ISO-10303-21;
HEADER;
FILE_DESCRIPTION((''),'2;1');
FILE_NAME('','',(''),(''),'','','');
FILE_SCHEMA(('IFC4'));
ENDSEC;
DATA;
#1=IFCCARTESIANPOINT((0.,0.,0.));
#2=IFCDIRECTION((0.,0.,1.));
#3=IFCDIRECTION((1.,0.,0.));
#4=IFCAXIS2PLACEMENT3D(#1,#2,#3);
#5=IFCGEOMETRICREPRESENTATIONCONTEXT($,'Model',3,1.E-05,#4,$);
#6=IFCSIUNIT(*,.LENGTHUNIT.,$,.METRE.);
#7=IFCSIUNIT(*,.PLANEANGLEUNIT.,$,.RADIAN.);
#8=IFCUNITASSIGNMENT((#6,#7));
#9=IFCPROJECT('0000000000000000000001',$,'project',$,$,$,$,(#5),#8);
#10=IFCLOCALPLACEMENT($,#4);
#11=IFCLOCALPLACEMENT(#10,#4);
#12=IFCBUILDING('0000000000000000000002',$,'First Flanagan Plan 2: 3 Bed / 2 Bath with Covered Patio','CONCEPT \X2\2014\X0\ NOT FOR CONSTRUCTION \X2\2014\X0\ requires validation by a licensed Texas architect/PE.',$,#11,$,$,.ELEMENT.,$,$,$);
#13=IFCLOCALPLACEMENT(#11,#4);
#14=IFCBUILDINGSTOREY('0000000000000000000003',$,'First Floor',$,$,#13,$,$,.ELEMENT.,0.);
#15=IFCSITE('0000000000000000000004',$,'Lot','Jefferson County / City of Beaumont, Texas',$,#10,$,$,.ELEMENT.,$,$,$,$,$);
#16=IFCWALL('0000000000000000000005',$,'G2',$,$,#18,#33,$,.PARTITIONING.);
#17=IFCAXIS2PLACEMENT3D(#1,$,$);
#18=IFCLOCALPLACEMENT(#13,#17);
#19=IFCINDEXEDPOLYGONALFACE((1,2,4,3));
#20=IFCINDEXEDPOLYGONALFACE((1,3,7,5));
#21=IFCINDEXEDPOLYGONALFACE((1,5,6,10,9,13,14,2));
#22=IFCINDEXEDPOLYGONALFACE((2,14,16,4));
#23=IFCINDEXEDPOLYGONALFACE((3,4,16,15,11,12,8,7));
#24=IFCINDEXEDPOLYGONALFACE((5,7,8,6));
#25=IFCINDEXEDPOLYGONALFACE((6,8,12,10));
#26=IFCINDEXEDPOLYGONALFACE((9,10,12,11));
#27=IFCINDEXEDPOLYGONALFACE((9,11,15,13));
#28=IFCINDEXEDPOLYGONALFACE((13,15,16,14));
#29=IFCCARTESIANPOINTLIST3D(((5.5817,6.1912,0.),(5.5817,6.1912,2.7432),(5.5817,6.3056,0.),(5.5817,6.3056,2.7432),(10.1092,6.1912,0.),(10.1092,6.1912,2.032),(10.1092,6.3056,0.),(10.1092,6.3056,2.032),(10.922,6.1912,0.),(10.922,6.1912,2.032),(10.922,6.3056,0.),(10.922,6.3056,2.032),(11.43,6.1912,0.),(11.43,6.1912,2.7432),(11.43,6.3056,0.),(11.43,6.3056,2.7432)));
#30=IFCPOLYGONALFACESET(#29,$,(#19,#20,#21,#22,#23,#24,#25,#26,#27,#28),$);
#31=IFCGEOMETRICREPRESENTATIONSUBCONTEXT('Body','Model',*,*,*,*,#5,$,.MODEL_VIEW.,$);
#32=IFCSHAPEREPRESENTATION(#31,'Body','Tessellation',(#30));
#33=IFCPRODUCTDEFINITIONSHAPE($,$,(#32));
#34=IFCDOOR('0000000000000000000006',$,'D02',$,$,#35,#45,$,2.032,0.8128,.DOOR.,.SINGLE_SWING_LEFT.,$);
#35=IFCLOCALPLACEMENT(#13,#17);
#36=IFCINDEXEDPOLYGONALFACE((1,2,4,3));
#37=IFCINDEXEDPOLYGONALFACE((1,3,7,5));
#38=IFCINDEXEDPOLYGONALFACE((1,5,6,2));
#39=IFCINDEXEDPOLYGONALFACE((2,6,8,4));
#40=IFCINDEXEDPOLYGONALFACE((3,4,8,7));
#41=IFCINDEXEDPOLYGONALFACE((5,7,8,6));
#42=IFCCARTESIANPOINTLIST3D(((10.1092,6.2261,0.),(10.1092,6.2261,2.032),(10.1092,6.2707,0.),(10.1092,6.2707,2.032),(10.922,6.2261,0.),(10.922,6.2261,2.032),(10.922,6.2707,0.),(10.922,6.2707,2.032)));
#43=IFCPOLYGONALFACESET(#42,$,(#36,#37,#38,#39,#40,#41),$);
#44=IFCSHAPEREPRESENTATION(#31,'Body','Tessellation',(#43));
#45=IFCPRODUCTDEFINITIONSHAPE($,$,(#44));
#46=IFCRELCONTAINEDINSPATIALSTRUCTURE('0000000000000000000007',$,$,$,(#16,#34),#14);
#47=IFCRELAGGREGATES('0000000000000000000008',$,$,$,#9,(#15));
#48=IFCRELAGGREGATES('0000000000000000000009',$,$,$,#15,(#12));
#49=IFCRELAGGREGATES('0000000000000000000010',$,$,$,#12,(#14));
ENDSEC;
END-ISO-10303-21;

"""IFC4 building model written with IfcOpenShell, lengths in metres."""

from ifc_helpers import new_model, si_unit, frame, frame_2d, origin_with_axes, place, context, subcontext, project, spatial, rectangle, extrude, element, fill, save


model = new_model("IFC4")

# Units and contexts
model_context = context("Model", 3, precision=1e-05, world=origin_with_axes())
body_context = subcontext(model_context, "Body", "Model", "MODEL_VIEW")
ifc_project = project(units=[si_unit("LENGTHUNIT", "METRE"), si_unit("PLANEANGLEUNIT", "RADIAN")], contexts=[model_context])

# Site, building, storey
site_placement = place(None, origin_with_axes())
site = spatial("IfcSite", under=ifc_project, at=site_placement, Name="Lot", Description="Jefferson County / City of Beaumont, Texas", CompositionType="ELEMENT")
building_placement = place(site_placement, origin_with_axes())
building = spatial("IfcBuilding", under=site, at=building_placement, Name="First Flanagan Plan 2: 3 Bed / 2 Bath with Covered Patio", Description="CONCEPT — NOT FOR CONSTRUCTION — requires validation by a licensed Texas architect/PE.", CompositionType="ELEMENT")
storey_placement = place(building_placement, origin_with_axes())
storey = spatial("IfcBuildingStorey", under=building, at=storey_placement, Name="First Floor", CompositionType="ELEMENT", Elevation=0.0)

# Wall, opening, door
wall_1_placement = place(storey_placement, frame((5.5817, 6.2484, 0.0), z_axis=(0.0, 0.0, 1.0), x_axis=(1.0, 0.0, 0.0)))
wall_1 = element("IfcWall", 1, at=wall_1_placement, inside=storey, Name="G2", PredefinedType="PARTITIONING", context=body_context, shape_type="SweptSolid", body=[
    extrude(rectangle(XDim=5.8483, YDim=0.1143, at=frame_2d((2.9242, 0.0), x_axis=(1.0, 0.0))), origin_with_axes(), (0.0, 0.0, 1.0), 2.7432),
])
opening_1_placement = place(wall_1_placement, frame((4.5275, 0.0, 0.0), z_axis=(0.0, 0.0, 1.0), x_axis=(1.0, 0.0, 0.0)))
opening_1 = element("IfcOpeningElement", 2, at=opening_1_placement, cuts=wall_1, PredefinedType="OPENING", context=body_context, shape_type="SweptSolid", body=[
    extrude(rectangle(XDim=0.8128, YDim=0.1448, at=frame_2d((0.4064, 0.0), x_axis=(1.0, 0.0))), origin_with_axes(), (0.0, 0.0, 1.0), 2.032),
])
door_1_placement = place(opening_1_placement, origin_with_axes())
door_1 = element("IfcDoor", 3, at=door_1_placement, inside=storey, Name="D02", OperationType="SINGLE_SWING_LEFT", OverallHeight=2.032, OverallWidth=0.8128, PredefinedType="DOOR", context=body_context, shape_type="SweptSolid", body=[
    extrude(rectangle(XDim=0.8128, YDim=0.0445, at=frame_2d((0.4064, 0.0), x_axis=(1.0, 0.0))), origin_with_axes(), (0.0, 0.0, 1.0), 2.032),
])
fill(opening_1, door_1)

save(model, "model.ifc")
